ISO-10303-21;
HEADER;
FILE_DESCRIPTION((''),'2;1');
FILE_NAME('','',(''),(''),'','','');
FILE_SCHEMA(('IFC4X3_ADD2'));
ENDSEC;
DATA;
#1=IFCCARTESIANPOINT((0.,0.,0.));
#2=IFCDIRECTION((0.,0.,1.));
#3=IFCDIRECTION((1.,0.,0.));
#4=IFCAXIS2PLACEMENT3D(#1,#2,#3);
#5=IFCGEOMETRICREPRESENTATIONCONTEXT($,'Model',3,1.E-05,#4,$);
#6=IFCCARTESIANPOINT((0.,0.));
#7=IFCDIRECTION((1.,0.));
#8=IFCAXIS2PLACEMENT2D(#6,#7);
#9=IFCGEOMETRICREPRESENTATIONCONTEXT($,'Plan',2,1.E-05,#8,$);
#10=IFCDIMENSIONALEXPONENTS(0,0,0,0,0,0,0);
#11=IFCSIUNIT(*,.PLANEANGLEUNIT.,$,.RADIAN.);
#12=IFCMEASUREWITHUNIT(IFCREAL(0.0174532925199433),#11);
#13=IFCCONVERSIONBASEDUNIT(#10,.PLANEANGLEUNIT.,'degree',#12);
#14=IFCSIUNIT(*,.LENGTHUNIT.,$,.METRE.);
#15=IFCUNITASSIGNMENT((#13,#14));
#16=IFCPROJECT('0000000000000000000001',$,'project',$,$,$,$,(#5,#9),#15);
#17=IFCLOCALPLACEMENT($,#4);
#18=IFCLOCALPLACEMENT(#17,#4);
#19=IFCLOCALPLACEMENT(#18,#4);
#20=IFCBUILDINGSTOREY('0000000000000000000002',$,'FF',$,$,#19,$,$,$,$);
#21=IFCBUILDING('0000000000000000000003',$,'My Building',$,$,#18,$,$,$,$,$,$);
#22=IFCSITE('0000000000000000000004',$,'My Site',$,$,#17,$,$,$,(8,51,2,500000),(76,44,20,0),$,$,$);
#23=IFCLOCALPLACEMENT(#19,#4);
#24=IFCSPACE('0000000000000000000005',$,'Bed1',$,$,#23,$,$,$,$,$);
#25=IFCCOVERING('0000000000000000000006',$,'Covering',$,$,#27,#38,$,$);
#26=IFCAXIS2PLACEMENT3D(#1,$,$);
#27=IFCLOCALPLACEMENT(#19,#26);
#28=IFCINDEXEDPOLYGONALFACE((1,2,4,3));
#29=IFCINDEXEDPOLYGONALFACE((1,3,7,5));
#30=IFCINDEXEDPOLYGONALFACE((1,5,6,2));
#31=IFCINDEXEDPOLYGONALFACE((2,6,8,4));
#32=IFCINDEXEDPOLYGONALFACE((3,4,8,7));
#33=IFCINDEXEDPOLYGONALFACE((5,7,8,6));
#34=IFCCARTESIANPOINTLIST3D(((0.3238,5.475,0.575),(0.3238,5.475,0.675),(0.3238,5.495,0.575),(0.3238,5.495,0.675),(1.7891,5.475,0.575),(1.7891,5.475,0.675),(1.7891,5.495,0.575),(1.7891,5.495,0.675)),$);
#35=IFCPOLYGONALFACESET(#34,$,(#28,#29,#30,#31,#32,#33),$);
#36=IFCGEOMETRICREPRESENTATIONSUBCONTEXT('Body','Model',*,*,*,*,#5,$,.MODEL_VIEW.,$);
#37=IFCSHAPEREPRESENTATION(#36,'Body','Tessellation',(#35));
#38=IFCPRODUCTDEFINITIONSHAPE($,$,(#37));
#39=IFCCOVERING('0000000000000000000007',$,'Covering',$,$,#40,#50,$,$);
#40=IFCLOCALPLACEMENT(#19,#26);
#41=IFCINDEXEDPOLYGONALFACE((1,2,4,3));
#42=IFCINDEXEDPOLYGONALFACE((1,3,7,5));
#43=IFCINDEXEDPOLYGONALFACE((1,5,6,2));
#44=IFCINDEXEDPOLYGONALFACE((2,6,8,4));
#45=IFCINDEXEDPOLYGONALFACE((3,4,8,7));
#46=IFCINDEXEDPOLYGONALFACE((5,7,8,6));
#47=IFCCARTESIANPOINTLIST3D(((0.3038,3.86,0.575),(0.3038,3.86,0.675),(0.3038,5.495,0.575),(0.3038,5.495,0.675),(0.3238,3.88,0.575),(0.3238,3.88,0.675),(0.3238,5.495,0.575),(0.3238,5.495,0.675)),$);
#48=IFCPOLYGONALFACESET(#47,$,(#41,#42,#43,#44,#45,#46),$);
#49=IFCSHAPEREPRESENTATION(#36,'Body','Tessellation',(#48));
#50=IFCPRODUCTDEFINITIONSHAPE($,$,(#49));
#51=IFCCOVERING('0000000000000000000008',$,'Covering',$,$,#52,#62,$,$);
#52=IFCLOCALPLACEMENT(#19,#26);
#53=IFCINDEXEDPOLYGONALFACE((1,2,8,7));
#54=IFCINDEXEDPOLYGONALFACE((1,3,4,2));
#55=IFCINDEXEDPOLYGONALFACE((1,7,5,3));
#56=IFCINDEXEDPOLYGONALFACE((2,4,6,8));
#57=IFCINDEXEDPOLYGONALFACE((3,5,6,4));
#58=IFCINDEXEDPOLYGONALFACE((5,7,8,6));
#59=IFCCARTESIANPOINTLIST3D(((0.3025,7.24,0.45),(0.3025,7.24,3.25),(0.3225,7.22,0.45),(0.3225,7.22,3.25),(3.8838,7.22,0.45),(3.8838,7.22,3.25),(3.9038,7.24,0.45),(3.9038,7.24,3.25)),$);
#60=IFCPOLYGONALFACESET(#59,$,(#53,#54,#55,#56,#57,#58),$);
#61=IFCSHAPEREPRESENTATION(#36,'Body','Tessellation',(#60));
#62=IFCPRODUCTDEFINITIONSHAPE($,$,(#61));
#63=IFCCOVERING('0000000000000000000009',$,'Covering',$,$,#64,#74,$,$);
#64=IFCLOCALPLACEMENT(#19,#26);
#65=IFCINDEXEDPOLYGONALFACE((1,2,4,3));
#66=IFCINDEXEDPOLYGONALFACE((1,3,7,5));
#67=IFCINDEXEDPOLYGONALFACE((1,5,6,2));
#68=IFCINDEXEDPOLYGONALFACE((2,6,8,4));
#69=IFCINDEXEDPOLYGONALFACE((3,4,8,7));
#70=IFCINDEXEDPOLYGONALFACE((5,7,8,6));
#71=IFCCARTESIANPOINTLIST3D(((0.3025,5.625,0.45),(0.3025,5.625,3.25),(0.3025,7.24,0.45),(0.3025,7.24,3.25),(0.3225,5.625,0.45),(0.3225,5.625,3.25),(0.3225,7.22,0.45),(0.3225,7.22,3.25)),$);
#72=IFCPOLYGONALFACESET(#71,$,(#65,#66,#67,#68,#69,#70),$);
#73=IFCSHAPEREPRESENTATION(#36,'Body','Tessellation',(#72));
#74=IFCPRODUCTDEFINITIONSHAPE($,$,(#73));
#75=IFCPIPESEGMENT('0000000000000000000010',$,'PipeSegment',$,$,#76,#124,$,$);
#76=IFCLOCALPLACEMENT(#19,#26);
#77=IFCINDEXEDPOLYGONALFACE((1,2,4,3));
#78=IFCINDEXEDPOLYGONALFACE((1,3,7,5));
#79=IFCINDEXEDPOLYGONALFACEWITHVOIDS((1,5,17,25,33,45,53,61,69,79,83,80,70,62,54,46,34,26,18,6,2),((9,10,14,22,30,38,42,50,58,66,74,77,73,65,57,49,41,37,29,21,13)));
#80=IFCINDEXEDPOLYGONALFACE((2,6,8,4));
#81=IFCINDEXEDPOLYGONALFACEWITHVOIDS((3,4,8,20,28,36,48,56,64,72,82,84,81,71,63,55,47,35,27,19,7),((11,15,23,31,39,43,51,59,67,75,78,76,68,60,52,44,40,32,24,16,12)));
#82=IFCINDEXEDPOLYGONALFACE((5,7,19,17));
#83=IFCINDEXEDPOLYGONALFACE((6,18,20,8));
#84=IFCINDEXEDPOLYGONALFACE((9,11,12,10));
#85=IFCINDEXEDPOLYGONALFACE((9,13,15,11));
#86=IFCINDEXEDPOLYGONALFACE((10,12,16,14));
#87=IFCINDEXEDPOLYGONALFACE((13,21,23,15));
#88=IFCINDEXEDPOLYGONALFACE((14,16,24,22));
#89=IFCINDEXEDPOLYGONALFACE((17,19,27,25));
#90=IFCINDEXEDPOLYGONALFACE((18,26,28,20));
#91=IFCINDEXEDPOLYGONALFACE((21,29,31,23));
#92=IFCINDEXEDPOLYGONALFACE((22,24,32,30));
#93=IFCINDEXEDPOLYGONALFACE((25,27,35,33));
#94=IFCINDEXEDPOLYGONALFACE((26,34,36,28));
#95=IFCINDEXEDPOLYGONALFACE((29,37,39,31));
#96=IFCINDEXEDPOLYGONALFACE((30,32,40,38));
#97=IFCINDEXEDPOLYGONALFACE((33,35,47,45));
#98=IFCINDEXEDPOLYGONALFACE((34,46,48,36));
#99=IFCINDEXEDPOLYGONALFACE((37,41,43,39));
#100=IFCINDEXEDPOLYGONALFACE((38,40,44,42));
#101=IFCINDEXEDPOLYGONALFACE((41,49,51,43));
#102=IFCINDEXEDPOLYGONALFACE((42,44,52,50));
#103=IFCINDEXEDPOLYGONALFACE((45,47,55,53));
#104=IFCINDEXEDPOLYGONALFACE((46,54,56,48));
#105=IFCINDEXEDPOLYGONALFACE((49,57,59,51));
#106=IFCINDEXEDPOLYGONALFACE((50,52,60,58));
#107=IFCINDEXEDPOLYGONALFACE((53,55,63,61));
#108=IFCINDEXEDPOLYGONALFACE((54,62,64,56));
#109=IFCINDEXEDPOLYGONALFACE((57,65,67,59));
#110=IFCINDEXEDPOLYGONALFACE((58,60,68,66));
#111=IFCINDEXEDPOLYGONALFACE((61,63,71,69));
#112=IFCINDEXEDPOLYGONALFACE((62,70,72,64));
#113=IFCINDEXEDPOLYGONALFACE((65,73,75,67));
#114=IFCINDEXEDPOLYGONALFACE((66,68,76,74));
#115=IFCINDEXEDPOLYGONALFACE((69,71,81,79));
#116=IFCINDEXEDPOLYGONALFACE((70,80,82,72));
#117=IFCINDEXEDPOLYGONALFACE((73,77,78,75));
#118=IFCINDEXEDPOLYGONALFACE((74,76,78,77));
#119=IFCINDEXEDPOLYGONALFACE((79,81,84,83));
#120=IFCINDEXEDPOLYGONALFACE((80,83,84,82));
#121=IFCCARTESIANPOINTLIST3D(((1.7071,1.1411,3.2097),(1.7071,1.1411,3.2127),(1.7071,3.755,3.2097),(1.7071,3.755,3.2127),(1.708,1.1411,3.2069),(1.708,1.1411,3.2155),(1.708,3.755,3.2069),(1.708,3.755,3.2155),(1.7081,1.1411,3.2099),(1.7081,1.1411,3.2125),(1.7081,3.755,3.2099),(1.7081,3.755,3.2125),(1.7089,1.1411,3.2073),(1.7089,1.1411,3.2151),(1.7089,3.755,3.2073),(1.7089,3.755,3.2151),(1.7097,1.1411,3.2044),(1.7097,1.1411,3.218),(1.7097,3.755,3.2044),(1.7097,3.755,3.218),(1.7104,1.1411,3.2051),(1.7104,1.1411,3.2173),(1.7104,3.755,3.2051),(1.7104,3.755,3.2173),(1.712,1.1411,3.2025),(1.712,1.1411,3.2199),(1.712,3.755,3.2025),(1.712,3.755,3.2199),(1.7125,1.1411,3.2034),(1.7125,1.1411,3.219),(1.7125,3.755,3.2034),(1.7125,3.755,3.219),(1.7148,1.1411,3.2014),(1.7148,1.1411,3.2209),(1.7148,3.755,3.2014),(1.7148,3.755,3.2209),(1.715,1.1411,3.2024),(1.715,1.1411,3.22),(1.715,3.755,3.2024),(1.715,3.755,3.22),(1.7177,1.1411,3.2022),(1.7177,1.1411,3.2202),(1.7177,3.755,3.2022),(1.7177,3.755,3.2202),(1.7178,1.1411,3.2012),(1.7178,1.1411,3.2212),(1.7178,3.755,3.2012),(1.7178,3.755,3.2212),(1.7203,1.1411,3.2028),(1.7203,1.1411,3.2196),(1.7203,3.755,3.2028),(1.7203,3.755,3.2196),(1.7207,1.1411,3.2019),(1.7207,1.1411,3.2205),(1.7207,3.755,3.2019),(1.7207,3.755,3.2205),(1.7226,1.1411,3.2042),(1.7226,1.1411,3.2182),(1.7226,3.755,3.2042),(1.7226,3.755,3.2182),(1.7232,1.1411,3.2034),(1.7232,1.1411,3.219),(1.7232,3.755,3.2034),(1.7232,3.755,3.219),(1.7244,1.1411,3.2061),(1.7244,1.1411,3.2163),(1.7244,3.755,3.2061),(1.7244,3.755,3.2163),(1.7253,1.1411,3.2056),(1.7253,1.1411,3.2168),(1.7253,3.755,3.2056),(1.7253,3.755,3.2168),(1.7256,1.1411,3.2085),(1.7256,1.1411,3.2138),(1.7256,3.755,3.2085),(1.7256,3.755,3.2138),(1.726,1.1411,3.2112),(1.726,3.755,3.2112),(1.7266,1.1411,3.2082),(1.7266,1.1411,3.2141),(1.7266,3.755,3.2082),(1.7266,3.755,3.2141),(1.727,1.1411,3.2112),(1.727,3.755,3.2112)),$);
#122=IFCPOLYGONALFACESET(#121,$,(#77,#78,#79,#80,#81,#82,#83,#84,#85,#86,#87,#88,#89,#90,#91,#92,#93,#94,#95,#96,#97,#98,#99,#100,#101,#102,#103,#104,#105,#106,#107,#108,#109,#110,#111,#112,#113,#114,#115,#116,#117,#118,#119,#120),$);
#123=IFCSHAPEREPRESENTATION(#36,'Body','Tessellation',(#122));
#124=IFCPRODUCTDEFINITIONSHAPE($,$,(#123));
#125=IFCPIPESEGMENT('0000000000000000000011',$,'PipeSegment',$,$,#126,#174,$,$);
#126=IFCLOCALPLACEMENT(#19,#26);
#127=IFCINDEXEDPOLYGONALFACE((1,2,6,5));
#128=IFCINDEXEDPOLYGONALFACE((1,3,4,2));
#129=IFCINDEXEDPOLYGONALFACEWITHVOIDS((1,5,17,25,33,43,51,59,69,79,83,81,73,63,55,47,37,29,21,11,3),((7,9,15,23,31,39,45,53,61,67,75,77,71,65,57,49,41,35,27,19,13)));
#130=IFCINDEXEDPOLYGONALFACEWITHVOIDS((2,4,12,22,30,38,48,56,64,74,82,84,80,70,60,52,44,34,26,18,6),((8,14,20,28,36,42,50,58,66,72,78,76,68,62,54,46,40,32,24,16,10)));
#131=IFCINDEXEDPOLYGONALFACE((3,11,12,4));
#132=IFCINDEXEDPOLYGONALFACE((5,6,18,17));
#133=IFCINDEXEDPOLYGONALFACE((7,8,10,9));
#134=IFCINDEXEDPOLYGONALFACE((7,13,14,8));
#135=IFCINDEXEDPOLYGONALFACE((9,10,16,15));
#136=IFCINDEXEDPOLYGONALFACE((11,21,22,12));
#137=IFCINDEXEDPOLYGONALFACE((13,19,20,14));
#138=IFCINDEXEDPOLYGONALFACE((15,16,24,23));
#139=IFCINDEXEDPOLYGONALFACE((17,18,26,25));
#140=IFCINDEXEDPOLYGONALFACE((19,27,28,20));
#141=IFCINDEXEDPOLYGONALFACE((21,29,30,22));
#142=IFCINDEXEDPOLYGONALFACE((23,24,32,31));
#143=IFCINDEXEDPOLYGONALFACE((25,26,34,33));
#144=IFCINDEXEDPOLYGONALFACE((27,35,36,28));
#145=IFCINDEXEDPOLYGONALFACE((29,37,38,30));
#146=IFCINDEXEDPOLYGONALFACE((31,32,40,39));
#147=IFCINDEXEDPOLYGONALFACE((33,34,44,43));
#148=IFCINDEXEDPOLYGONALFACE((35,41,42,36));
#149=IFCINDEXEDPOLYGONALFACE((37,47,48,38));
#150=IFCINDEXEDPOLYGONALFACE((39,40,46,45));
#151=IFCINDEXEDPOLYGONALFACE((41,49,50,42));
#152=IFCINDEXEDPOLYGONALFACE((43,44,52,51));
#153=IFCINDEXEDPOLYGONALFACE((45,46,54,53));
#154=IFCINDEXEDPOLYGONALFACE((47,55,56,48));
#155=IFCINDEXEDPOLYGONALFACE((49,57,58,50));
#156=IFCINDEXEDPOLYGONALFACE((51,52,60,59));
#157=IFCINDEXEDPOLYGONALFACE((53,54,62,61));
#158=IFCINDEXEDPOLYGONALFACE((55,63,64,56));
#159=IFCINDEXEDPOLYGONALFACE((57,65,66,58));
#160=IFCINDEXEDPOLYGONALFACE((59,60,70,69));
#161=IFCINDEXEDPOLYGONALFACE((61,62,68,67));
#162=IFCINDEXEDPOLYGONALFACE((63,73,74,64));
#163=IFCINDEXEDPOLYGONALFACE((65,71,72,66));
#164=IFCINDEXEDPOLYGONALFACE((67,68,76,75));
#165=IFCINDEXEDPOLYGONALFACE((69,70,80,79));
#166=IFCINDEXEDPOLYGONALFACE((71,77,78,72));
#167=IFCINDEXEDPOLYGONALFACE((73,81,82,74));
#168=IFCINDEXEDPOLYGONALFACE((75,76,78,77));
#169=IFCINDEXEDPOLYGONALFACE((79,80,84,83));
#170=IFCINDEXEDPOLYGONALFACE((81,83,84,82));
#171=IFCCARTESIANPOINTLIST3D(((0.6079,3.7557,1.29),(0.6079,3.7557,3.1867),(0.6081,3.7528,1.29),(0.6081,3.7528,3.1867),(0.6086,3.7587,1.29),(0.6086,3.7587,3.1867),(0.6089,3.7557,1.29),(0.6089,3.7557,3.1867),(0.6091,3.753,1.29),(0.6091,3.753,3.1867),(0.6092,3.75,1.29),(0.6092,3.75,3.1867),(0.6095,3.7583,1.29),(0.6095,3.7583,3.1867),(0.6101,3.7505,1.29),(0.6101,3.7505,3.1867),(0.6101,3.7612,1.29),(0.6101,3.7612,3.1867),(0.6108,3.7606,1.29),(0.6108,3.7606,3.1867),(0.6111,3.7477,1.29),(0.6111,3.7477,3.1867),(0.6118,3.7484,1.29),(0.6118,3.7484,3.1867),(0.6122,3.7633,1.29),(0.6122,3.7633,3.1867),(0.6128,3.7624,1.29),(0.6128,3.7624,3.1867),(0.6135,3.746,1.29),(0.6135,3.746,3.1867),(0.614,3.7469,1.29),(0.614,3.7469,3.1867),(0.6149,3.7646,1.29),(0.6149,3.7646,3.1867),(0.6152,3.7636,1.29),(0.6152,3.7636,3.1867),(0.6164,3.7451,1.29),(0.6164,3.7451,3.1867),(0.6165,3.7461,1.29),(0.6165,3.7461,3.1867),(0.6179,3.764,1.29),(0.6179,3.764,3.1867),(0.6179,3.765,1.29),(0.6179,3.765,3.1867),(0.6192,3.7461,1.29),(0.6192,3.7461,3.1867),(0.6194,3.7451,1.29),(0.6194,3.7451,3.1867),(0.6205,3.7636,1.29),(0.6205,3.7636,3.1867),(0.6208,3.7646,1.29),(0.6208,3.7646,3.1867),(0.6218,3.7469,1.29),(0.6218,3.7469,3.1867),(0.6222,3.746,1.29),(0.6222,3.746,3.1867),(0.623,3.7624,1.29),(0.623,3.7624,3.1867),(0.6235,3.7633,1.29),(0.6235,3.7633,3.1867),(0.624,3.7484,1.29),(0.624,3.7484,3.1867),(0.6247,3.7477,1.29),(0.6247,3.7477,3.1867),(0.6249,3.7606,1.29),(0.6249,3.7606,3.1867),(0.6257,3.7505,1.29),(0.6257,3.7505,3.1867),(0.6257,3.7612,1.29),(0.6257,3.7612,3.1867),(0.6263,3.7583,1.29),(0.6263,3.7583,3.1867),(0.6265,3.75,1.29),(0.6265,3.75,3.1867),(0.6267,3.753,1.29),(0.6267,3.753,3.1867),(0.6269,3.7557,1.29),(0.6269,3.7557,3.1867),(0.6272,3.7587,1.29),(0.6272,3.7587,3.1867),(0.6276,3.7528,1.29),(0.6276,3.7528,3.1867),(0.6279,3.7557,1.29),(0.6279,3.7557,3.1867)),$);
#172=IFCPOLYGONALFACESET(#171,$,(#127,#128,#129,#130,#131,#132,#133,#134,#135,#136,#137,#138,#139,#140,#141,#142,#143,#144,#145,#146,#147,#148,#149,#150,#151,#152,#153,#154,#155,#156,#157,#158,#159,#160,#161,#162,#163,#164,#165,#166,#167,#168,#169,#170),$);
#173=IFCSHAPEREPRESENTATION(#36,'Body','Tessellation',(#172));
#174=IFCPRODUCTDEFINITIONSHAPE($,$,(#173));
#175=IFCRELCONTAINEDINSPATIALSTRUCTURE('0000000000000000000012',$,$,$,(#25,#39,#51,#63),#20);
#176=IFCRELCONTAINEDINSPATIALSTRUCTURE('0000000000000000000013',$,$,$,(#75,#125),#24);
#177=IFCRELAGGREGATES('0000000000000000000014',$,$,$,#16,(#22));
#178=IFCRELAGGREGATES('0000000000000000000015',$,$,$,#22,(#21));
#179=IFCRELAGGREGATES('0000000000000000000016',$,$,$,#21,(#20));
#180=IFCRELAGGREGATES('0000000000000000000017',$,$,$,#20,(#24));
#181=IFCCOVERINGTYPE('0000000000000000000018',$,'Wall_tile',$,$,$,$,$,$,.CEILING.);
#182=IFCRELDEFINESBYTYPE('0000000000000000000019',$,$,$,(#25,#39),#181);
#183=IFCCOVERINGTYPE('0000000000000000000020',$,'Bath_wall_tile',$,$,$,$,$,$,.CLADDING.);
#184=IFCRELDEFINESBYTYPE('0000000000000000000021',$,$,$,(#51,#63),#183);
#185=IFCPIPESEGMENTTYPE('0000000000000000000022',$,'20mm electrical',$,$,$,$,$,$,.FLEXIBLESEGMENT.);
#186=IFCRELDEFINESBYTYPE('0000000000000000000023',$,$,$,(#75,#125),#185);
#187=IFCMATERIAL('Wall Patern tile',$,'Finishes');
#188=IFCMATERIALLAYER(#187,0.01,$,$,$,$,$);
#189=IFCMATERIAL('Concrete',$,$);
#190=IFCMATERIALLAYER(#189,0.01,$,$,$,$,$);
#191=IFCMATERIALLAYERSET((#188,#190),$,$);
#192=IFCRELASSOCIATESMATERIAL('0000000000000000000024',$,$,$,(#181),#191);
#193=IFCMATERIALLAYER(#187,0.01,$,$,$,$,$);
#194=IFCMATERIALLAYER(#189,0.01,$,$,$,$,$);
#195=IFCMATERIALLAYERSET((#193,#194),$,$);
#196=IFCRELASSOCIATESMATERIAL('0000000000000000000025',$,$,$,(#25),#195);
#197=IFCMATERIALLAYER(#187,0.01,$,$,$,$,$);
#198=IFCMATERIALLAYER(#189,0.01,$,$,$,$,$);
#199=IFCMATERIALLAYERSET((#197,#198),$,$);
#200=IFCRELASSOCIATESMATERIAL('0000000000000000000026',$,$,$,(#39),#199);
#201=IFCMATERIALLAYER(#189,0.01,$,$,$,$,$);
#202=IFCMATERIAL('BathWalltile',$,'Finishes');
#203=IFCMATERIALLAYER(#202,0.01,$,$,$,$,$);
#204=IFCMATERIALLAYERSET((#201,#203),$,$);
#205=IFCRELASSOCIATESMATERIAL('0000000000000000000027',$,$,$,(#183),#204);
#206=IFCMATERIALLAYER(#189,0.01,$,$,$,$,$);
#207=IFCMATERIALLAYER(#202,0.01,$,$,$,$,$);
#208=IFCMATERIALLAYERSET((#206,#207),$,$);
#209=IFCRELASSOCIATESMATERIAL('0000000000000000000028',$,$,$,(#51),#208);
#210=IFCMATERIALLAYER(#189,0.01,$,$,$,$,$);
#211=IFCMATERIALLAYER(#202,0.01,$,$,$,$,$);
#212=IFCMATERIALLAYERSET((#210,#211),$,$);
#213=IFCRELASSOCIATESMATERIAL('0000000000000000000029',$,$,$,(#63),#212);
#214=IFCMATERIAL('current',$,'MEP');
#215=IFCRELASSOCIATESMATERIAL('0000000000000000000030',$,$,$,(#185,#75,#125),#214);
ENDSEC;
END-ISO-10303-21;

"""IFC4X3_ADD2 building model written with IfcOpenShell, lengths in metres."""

from ifc_helpers import new_model, entity, si_unit, converted_unit, frame, origin_with_axes, origin_2d_with_axis, place, context, subcontext, project, spatial, line, indexed_curve, hollow_circle, outline, extrude, material, layer, layer_set, layer_usage, material_profile, profile_set, profile_usage, type_object, element, save


model = new_model("IFC4X3_ADD2")

# Units and contexts
model_context = context("Model", 3, precision=1e-05, world=origin_with_axes())
plan_context = context("Plan", 2, precision=1e-05, world=origin_2d_with_axis())
body_context_1 = subcontext(model_context, "Body", "Model", "MODEL_VIEW")
ifc_project = project(units=[converted_unit("PLANEANGLEUNIT", "degree", entity("IfcReal", 0.0174532925199433), si_unit("PLANEANGLEUNIT", "RADIAN"), dimensions=[0, 0, 0, 0, 0, 0, 0]), si_unit("LENGTHUNIT", "METRE")], contexts=[model_context, plan_context])

# Site, building, storey
site_placement = place(None, origin_with_axes())
site = spatial("IfcSite", under=ifc_project, at=site_placement, Name="My Site", RefLatitude=(8, 51, 2, 500000), RefLongitude=(76, 44, 20, 0))
building_placement = place(site_placement, origin_with_axes())
building = spatial("IfcBuilding", under=site, at=building_placement, Name="My Building")
storey_placement = place(building_placement, origin_with_axes())
storey = spatial("IfcBuildingStorey", under=building, at=storey_placement, Name="FF")

# Coverings
ifc_material_1 = material(Name="Wall Patern tile", Category="Finishes")
ifc_material_2 = material(Name="Concrete")
ifc_layer_1 = layer(ifc_material_1, 0.01)
ifc_layer_2 = layer(ifc_material_2, 0.01)
ifc_layer_set_1 = layer_set([ifc_layer_1, ifc_layer_2])
covering_type_1 = type_object("IfcCoveringType", Name="Wall_tile", PredefinedType="CEILING", material=ifc_layer_set_1)
ifc_layer_3 = layer(ifc_material_1, 0.01)
ifc_layer_4 = layer(ifc_material_2, 0.01)
ifc_layer_set_2 = layer_set([ifc_layer_3, ifc_layer_4])
ifc_layer_usage_1 = layer_usage(ifc_layer_set_2, "AXIS2", "POSITIVE", 0.0)
covering_1_placement = place(storey_placement, frame((0.3238, 5.475, 0.575), z_axis=(0.0, 0.0, 1.0), x_axis=(1.0, 0.0, 0.0)))
element("IfcCovering", 1, at=covering_1_placement, inside=storey, type_object=covering_type_1, material=ifc_layer_usage_1, Name="Covering", context=body_context_1, shape_type="SweptSolid", body=[
    extrude(outline(indexed_curve([(0.0, 0.0), (0.0, 0.02), (1.4652, 0.02), (1.4652, 0.0)], segments=[line(1, 2, 3, 4, 1)])), origin_with_axes(), (0.0, 0.0, 1.0), 0.1),
])
ifc_layer_5 = layer(ifc_material_1, 0.01)
ifc_layer_6 = layer(ifc_material_2, 0.01)
ifc_layer_set_3 = layer_set([ifc_layer_5, ifc_layer_6])
ifc_layer_usage_2 = layer_usage(ifc_layer_set_3, "AXIS2", "NEGATIVE", 0.0)
covering_2_placement = place(storey_placement, frame((0.3238, 5.495, 0.575), z_axis=(0.0, 0.0, 1.0), x_axis=(0.0, -1.0, 0.0)))
element("IfcCovering", 2, at=covering_2_placement, inside=storey, type_object=covering_type_1, material=ifc_layer_usage_2, Name="Covering", context=body_context_1, shape_type="SweptSolid", body=[
    extrude(outline(indexed_curve([(0.0, -0.02), (0.0, 0.0), (1.615, 0.0), (1.635, -0.02)], segments=[line(1, 2, 3, 4, 1)])), origin_with_axes(), (0.0, 0.0, 1.0), 0.1),
])
ifc_layer_7 = layer(ifc_material_2, 0.01)
ifc_material_3 = material(Name="BathWalltile", Category="Finishes")
ifc_layer_8 = layer(ifc_material_3, 0.01)
ifc_layer_set_4 = layer_set([ifc_layer_7, ifc_layer_8])
ifc_layer_usage_3 = layer_usage(ifc_layer_set_4, "AXIS2", "NEGATIVE", 0.0)
ifc_layer_9 = layer(ifc_material_2, 0.01)
ifc_layer_10 = layer(ifc_material_3, 0.01)
ifc_layer_set_5 = layer_set([ifc_layer_9, ifc_layer_10])
covering_type_2 = type_object("IfcCoveringType", Name="Bath_wall_tile", PredefinedType="CLADDING", material=ifc_layer_set_5)
covering_3_placement = place(storey_placement, frame((0.3025, 7.24, 0.45), z_axis=(0.0, 0.0, 1.0), x_axis=(1.0, 0.0, 0.0)))
element("IfcCovering", 3, at=covering_3_placement, inside=storey, type_object=covering_type_2, material=ifc_layer_usage_3, Name="Covering", context=body_context_1, shape_type="SweptSolid", body=[
    extrude(outline(indexed_curve([(0.02, -0.02), (0.0, 0.0), (3.6013, 0.0), (3.5813, -0.02)], segments=[line(1, 2, 3, 4, 1)])), origin_with_axes(), (0.0, 0.0, 1.0), 2.8),
])
ifc_layer_11 = layer(ifc_material_2, 0.01)
ifc_layer_12 = layer(ifc_material_3, 0.01)
ifc_layer_set_6 = layer_set([ifc_layer_11, ifc_layer_12])
ifc_layer_usage_4 = layer_usage(ifc_layer_set_6, "AXIS2", "POSITIVE", 0.0)
covering_4_placement = place(storey_placement, frame((0.3025, 7.24, 0.45), z_axis=(0.0, 0.0, 1.0), x_axis=(0.0, -1.0, 0.0)))
element("IfcCovering", 4, at=covering_4_placement, inside=storey, type_object=covering_type_2, material=ifc_layer_usage_4, Name="Covering", context=body_context_1, shape_type="SweptSolid", body=[
    extrude(outline(indexed_curve([(0.0, 0.0), (0.02, 0.02), (1.615, 0.02), (1.615, 0.0)], segments=[line(1, 2, 3, 4, 1)])), origin_with_axes(), (0.0, 0.0, 1.0), 2.8),
])

# Shared definitions
space_1_placement = place(storey_placement, origin_with_axes())
space_1 = spatial("IfcSpace", under=storey, at=space_1_placement, Name="Bed1")

# Pipe segments
ifc_material_4 = material(Name="current", Category="MEP")
ifc_material_profile_1 = material_profile(ifc_material_4, hollow_circle(Radius=0.01, WallThickness=0.001))
ifc_profile_set_1 = profile_set([ifc_material_profile_1], Name="current")
ifc_profile_usage_1 = profile_usage(ifc_profile_set_1, cardinal=5)
pipe_segment_type = type_object("IfcPipeSegmentType", Name="20mm electrical", PredefinedType="FLEXIBLESEGMENT", material=ifc_profile_set_1)
pipe_segment_1_placement = place(space_1_placement, frame((1.717, 3.755, 3.2112), z_axis=(0.0, -1.0, 0.0), x_axis=(1.0, 0.0, 0.0)))
element("IfcPipeSegment", 5, at=pipe_segment_1_placement, inside=space_1, type_object=pipe_segment_type, material=ifc_profile_usage_1, Name="PipeSegment", context=body_context_1, shape_type="SweptSolid", body=[
    extrude(hollow_circle(Radius=0.01, WallThickness=0.001), origin_with_axes(), (0.0, 0.0, 1.0), 2.6139),
])
ifc_profile_usage_2 = profile_usage(ifc_profile_set_1, cardinal=5)
pipe_segment_2_placement = place(space_1_placement, frame((0.6179, 3.755, 1.29), z_axis=(0.0, 0.0, 1.0), x_axis=(0.0, 1.0, 0.0)))
element("IfcPipeSegment", 6, at=pipe_segment_2_placement, inside=space_1, type_object=pipe_segment_type, material=ifc_profile_usage_2, Name="PipeSegment", context=body_context_1, shape_type="SweptSolid", body=[
    extrude(hollow_circle(Radius=0.01, WallThickness=0.001), origin_with_axes(), (0.0, 0.0, 1.0), 1.8967),
])

save(model, "model.ifc")
